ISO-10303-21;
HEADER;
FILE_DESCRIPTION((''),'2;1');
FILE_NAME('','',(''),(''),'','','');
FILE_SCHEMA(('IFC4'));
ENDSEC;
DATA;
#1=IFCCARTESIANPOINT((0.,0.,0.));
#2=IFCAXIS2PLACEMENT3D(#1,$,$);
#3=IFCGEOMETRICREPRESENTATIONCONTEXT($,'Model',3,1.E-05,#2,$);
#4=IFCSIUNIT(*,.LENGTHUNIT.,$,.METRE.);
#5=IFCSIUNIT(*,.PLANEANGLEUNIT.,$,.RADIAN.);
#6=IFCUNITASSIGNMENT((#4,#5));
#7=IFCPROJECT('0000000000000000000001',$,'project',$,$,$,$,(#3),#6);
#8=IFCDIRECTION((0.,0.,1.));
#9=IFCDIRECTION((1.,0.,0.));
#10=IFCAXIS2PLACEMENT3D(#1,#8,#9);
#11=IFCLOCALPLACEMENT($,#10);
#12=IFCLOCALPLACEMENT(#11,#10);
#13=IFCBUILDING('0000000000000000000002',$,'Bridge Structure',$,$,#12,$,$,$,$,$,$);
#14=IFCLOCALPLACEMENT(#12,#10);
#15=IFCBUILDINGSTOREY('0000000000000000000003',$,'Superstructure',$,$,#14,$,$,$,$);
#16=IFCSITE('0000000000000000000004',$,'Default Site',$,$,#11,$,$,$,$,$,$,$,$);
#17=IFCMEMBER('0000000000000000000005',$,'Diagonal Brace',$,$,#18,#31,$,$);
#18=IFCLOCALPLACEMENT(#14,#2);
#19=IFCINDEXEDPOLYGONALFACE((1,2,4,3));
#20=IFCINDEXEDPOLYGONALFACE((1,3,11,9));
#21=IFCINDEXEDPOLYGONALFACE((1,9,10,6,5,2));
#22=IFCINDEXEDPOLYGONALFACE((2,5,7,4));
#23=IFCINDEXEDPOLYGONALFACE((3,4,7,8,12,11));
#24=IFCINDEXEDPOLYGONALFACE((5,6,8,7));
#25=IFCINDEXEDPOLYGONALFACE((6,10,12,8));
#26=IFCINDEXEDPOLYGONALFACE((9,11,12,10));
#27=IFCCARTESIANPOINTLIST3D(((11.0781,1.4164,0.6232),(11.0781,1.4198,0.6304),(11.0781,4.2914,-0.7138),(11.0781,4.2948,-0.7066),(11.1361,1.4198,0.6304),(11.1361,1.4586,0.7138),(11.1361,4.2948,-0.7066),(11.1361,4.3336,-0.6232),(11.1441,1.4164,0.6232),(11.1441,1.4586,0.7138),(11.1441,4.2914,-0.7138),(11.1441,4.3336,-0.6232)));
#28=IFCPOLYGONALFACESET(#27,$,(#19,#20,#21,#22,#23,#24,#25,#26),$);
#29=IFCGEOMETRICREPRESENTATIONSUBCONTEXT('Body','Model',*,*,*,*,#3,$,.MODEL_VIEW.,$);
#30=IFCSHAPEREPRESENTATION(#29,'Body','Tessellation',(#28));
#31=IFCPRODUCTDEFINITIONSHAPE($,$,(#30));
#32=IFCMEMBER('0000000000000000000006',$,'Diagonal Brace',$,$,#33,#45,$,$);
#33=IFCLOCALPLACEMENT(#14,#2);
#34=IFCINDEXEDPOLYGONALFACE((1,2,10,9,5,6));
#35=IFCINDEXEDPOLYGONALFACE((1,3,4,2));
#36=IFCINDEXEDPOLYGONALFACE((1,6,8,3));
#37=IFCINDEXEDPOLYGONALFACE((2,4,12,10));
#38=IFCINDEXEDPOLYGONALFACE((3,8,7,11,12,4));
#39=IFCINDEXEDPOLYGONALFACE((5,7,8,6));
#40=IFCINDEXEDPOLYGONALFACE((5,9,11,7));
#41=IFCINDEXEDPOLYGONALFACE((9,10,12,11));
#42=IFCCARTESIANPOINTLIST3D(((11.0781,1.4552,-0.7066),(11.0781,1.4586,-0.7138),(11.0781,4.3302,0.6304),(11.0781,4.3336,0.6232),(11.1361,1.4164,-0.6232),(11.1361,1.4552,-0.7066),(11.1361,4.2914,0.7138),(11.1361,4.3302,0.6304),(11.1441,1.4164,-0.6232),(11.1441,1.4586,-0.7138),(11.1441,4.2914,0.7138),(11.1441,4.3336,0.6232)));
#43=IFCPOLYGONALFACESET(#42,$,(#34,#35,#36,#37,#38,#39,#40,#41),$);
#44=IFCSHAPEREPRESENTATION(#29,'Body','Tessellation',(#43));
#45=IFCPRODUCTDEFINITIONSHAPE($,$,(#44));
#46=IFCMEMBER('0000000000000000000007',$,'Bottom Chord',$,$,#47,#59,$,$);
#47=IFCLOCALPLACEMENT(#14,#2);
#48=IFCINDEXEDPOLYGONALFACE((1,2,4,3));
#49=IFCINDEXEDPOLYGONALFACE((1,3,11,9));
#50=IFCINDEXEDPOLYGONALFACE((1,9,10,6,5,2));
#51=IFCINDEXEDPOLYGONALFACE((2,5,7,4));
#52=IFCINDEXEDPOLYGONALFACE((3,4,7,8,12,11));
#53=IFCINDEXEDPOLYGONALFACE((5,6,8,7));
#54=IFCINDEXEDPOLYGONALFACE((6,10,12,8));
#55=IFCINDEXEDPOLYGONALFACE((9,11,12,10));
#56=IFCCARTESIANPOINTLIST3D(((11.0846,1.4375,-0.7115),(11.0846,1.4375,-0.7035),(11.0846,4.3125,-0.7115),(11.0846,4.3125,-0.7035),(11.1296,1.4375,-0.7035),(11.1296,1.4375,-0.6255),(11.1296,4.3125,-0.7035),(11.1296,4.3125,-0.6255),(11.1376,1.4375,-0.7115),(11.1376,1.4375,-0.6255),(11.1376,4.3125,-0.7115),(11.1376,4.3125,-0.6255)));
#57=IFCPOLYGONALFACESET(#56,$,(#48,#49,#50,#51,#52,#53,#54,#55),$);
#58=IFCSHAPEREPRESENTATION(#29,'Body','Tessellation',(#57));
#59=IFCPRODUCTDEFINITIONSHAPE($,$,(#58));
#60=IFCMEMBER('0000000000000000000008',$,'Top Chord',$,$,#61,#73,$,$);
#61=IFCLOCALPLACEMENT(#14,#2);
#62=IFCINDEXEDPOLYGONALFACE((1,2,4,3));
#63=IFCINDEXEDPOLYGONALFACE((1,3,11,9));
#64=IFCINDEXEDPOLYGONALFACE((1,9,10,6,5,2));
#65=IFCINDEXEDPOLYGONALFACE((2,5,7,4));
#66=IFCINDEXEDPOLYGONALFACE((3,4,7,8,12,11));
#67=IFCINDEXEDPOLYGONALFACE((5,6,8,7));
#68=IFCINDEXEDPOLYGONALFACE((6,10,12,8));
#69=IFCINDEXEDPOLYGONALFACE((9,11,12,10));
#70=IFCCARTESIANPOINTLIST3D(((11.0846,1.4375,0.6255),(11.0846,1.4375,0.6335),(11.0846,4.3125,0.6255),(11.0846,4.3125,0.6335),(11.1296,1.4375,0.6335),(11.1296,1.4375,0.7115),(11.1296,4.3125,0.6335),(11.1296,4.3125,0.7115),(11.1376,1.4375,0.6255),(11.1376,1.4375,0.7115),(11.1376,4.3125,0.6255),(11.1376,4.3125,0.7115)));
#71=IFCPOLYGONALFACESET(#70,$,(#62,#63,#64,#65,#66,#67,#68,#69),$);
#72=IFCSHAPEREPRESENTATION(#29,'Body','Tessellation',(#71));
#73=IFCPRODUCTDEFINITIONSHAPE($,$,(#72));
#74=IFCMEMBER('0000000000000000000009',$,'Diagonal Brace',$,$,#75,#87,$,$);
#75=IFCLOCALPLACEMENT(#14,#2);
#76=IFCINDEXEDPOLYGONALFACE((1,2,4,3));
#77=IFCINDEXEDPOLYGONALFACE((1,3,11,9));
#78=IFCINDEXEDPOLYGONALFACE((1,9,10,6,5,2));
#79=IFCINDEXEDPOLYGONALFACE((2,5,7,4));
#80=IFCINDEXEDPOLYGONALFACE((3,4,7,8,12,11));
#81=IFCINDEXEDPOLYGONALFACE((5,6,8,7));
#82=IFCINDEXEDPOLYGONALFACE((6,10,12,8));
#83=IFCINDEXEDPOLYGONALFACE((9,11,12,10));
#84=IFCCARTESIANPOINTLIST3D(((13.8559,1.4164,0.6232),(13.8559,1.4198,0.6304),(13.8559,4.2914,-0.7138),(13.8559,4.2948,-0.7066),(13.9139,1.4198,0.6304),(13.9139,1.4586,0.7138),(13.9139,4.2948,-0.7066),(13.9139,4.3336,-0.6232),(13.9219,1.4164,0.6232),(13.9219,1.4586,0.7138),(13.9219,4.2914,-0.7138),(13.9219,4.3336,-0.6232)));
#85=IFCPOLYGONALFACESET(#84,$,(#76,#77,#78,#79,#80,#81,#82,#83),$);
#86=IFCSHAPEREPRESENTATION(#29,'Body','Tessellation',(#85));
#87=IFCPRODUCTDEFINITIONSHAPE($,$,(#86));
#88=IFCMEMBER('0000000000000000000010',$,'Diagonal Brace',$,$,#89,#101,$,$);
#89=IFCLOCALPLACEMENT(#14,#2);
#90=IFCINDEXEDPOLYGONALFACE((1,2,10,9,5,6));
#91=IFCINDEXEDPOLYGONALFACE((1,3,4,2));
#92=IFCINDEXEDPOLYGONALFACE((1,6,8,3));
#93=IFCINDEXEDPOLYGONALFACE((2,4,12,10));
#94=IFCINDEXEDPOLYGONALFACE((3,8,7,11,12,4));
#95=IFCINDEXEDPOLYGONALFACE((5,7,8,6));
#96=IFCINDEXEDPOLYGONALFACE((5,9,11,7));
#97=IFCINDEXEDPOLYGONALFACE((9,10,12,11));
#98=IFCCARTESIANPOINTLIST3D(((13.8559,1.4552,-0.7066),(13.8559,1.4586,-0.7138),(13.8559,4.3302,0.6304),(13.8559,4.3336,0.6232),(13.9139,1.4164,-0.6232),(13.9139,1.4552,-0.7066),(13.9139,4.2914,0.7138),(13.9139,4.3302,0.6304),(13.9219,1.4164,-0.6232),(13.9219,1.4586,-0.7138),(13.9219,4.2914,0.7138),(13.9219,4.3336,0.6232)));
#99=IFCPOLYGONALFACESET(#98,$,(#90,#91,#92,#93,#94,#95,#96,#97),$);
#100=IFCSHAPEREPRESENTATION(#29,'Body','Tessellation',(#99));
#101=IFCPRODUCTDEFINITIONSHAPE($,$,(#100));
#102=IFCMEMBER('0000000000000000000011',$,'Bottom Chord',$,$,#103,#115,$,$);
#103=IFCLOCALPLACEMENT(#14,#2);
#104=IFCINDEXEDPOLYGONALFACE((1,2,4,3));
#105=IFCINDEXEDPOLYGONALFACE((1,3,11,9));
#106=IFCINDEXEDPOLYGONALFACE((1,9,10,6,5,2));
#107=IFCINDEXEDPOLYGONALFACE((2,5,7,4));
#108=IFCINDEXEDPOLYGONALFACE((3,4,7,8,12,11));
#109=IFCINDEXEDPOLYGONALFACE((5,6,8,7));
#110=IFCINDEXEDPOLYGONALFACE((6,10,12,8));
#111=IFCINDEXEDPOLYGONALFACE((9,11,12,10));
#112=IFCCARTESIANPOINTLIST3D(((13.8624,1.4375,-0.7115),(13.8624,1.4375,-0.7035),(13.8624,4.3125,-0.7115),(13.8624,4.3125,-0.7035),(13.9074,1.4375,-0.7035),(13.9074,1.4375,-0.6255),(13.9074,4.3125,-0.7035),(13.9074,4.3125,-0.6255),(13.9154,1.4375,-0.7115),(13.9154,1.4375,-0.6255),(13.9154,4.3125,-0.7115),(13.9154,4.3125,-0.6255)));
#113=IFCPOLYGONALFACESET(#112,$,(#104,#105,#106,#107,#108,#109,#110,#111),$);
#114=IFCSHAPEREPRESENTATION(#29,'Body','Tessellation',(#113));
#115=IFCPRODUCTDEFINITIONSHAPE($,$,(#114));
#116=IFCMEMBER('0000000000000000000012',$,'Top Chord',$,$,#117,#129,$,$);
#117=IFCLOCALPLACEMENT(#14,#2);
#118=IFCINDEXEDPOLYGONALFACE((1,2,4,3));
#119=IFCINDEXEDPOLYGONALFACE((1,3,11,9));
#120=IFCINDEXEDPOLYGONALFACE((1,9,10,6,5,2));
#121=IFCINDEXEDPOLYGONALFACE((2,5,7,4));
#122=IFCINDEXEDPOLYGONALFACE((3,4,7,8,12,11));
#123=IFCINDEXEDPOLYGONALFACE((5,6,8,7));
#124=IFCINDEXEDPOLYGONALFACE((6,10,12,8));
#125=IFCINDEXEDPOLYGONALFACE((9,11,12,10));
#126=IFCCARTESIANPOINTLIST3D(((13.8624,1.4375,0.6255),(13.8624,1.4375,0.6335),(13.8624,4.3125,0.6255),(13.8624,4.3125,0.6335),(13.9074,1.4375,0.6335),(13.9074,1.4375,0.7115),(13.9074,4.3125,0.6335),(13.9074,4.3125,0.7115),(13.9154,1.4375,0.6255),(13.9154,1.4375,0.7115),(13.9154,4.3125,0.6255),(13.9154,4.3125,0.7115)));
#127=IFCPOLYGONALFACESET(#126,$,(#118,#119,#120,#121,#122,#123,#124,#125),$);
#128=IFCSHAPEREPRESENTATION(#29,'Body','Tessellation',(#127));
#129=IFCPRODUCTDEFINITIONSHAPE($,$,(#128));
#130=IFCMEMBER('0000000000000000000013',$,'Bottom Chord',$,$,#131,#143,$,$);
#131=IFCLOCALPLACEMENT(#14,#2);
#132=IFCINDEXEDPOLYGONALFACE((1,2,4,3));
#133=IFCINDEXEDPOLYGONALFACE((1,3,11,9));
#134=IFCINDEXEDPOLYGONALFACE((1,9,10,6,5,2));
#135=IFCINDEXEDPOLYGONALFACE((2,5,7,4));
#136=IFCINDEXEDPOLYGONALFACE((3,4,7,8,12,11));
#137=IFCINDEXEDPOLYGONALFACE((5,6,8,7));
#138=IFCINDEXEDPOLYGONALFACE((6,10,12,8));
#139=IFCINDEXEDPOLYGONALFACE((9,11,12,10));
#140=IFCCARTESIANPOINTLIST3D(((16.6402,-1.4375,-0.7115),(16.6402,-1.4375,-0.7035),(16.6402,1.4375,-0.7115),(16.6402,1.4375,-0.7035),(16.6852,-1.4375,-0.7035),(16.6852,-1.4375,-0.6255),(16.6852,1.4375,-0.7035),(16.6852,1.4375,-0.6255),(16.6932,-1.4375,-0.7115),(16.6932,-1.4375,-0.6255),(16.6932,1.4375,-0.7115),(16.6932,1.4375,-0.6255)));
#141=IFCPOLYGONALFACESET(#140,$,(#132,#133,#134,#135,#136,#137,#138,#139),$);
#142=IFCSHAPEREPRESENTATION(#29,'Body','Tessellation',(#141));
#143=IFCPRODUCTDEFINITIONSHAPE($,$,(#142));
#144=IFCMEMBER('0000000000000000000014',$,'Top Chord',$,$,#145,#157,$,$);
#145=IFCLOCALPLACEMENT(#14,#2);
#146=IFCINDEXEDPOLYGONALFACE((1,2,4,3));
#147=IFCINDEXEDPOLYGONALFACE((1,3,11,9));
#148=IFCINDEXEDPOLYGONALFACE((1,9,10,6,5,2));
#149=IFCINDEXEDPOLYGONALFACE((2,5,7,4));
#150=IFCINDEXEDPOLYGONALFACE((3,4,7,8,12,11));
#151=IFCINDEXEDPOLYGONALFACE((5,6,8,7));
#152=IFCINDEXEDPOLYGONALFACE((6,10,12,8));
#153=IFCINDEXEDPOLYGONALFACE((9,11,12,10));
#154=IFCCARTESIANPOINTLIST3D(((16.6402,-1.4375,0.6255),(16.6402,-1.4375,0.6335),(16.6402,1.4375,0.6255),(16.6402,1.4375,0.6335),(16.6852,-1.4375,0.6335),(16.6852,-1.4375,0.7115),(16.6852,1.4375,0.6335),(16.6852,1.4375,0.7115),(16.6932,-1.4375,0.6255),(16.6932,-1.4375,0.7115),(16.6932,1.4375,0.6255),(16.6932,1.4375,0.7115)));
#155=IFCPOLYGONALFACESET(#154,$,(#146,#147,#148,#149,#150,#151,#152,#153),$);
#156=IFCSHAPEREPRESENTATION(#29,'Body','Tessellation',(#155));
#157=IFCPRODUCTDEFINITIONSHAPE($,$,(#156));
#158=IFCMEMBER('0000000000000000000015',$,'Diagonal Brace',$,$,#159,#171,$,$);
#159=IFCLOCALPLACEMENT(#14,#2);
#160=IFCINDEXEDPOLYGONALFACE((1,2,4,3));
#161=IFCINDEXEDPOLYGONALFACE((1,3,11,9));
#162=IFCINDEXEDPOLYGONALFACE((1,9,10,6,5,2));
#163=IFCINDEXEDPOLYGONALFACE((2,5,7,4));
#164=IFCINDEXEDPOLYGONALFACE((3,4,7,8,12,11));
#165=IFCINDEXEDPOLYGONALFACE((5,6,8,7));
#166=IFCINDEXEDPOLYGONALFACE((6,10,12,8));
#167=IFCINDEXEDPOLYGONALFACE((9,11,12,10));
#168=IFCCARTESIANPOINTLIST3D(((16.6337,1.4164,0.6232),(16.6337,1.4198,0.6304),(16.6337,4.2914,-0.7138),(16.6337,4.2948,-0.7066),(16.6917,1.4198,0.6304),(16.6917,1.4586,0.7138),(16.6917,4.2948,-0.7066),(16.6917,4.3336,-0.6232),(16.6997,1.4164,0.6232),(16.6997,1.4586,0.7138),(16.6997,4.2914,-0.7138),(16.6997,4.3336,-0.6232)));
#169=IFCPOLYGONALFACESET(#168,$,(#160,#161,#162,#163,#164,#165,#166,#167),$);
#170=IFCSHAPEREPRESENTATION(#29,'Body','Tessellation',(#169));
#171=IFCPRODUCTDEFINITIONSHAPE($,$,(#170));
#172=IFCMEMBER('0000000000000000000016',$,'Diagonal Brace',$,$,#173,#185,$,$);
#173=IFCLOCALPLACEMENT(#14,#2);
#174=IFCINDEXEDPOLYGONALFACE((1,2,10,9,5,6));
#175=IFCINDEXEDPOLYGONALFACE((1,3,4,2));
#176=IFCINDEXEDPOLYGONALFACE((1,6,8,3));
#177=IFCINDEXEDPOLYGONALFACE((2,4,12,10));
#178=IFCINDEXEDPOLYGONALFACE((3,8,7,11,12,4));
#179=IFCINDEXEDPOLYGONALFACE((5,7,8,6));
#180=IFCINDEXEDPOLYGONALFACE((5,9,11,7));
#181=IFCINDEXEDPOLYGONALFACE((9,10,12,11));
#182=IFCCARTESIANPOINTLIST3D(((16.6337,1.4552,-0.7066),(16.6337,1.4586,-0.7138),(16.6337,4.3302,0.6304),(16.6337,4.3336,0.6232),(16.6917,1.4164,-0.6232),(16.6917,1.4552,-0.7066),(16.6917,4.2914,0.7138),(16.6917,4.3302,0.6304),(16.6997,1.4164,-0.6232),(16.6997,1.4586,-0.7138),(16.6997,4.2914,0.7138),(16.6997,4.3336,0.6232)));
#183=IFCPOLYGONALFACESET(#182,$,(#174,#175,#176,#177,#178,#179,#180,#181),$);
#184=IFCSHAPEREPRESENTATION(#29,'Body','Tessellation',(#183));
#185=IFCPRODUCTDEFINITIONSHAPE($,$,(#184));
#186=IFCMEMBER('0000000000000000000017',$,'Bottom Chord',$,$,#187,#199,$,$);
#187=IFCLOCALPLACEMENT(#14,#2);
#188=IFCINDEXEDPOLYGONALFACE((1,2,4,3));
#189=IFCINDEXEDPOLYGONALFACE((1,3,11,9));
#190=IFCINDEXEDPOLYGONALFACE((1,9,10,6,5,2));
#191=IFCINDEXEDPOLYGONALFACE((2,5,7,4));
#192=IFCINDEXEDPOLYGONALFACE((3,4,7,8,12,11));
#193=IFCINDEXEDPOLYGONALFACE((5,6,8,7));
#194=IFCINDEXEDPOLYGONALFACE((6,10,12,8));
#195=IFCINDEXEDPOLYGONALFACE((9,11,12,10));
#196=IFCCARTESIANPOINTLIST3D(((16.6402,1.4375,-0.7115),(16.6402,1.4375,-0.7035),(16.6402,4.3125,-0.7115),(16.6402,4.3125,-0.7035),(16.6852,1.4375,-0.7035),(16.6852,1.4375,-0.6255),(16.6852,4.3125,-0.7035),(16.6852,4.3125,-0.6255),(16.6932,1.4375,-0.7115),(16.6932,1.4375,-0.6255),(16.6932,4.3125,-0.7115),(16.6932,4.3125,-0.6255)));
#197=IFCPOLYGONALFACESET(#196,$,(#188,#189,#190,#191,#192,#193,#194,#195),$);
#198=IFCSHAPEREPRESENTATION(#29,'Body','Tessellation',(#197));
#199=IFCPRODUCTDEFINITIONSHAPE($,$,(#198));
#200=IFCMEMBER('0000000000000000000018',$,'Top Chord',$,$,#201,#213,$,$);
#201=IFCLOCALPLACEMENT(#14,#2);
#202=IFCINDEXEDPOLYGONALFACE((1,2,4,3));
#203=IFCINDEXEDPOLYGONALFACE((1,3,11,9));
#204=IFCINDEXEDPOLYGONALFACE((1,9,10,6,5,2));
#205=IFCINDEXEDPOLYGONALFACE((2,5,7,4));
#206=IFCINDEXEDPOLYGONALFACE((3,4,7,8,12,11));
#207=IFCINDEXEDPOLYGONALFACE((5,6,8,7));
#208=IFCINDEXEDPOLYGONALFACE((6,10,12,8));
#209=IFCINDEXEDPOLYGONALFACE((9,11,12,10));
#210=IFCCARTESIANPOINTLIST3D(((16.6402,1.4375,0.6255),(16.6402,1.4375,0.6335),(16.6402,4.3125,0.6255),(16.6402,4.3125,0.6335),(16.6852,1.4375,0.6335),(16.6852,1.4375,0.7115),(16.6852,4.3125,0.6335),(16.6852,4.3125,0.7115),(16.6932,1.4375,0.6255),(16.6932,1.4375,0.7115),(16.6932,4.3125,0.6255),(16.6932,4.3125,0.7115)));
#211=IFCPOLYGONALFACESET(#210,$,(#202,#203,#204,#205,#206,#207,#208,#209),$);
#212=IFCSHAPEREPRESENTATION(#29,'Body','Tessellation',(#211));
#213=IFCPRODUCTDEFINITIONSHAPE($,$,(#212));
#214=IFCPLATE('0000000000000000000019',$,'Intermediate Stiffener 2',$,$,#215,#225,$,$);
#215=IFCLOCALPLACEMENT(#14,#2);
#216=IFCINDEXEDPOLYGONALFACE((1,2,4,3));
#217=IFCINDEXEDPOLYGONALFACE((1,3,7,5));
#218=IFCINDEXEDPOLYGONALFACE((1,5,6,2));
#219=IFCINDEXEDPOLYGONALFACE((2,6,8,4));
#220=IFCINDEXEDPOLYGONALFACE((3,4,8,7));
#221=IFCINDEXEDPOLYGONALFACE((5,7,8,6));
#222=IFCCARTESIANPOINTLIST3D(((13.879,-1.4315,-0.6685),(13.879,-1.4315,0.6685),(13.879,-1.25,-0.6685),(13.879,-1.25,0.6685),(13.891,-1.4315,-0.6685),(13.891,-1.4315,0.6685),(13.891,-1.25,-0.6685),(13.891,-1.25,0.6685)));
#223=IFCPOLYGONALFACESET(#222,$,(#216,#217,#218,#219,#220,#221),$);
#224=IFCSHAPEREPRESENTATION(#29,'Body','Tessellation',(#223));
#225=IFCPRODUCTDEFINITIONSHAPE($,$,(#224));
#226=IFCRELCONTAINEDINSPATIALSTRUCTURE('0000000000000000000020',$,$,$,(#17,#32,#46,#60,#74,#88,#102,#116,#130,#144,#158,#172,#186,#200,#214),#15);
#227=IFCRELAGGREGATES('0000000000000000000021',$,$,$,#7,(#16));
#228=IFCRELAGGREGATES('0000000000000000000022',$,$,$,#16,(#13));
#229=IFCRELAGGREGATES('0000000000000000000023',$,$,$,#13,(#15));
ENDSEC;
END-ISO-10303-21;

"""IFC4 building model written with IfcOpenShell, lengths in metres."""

from ifc_helpers import new_model, si_unit, frame, origin, origin_with_axes, origin_2d_with_axis, place, context, subcontext, project, spatial, rectangle, l_section, extrude, element, save


model = new_model("IFC4")

# Units and contexts
model_context = context("Model", 3, precision=1e-05, world=origin())
body_context = subcontext(model_context, "Body", "Model", "MODEL_VIEW")
ifc_project = project(units=[si_unit("LENGTHUNIT", "METRE"), si_unit("PLANEANGLEUNIT", "RADIAN")], contexts=[model_context])

# Site, building, storey
site_placement = place(None, origin_with_axes())
site = spatial("IfcSite", under=ifc_project, at=site_placement, Name="Default Site")
building_placement = place(site_placement, origin_with_axes())
building = spatial("IfcBuilding", under=site, at=building_placement, Name="Bridge Structure")
storey_placement = place(building_placement, origin_with_axes())
storey = spatial("IfcBuildingStorey", under=building, at=storey_placement, Name="Superstructure")

# Members
for number, where, z_axis, x_axis, name in (
    (1, (11.1111, 1.4375, 0.6685), (0.0, 0.906746, -0.421676), (-1.0, 0.0, 0.0), "Diagonal Brace"),
    (2, (11.1111, 1.4375, -0.6685), (0.0, 0.906746, 0.421676), (-1.0, 0.0, 0.0), "Diagonal Brace"),
):
    element("IfcMember", number, at=place(storey_placement, frame(where, z_axis=z_axis, x_axis=x_axis)), inside=storey, Name=name, context=body_context, shape_type="SweptSolid", body=[
        extrude(l_section(Depth=0.1, Width=0.066, Thickness=0.008, at=origin_2d_with_axis()), origin_with_axes(), (0.0, 0.0, 1.0), 3.1707),
    ])
for number, where, z_axis, x_axis, name in (
    (3, (11.1111, 1.4375, -0.6685), (0.0, 1.0, 0.0), (-1.0, 0.0, 0.0), "Bottom Chord"),
    (4, (11.1111, 1.4375, 0.6685), (0.0, 1.0, 0.0), (-1.0, 0.0, 0.0), "Top Chord"),
):
    element("IfcMember", number, at=place(storey_placement, frame(where, z_axis=z_axis, x_axis=x_axis)), inside=storey, Name=name, context=body_context, shape_type="SweptSolid", body=[
        extrude(l_section(Depth=0.086, Width=0.053, Thickness=0.008, at=origin_2d_with_axis()), origin_with_axes(), (0.0, 0.0, 1.0), 2.875),
    ])
for number, where, z_axis, x_axis, name in (
    (5, (13.8889, 1.4375, 0.6685), (0.0, 0.906746, -0.421676), (-1.0, 0.0, 0.0), "Diagonal Brace"),
    (6, (13.8889, 1.4375, -0.6685), (0.0, 0.906746, 0.421676), (-1.0, 0.0, 0.0), "Diagonal Brace"),
):
    element("IfcMember", number, at=place(storey_placement, frame(where, z_axis=z_axis, x_axis=x_axis)), inside=storey, Name=name, context=body_context, shape_type="SweptSolid", body=[
        extrude(l_section(Depth=0.1, Width=0.066, Thickness=0.008, at=origin_2d_with_axis()), origin_with_axes(), (0.0, 0.0, 1.0), 3.1707),
    ])
for number, where, z_axis, x_axis, name in (
    (7, (13.8889, 1.4375, -0.6685), (0.0, 1.0, 0.0), (-1.0, 0.0, 0.0), "Bottom Chord"),
    (8, (13.8889, 1.4375, 0.6685), (0.0, 1.0, 0.0), (-1.0, 0.0, 0.0), "Top Chord"),
    (9, (16.6667, -1.4375, -0.6685), (0.0, 1.0, 0.0), (-1.0, 0.0, 0.0), "Bottom Chord"),
    (10, (16.6667, -1.4375, 0.6685), (0.0, 1.0, 0.0), (-1.0, 0.0, 0.0), "Top Chord"),
):
    element("IfcMember", number, at=place(storey_placement, frame(where, z_axis=z_axis, x_axis=x_axis)), inside=storey, Name=name, context=body_context, shape_type="SweptSolid", body=[
        extrude(l_section(Depth=0.086, Width=0.053, Thickness=0.008, at=origin_2d_with_axis()), origin_with_axes(), (0.0, 0.0, 1.0), 2.875),
    ])
for number, where, z_axis, x_axis, name in (
    (11, (16.6667, 1.4375, 0.6685), (0.0, 0.906746, -0.421676), (-1.0, 0.0, 0.0), "Diagonal Brace"),
    (12, (16.6667, 1.4375, -0.6685), (0.0, 0.906746, 0.421676), (-1.0, 0.0, 0.0), "Diagonal Brace"),
):
    element("IfcMember", number, at=place(storey_placement, frame(where, z_axis=z_axis, x_axis=x_axis)), inside=storey, Name=name, context=body_context, shape_type="SweptSolid", body=[
        extrude(l_section(Depth=0.1, Width=0.066, Thickness=0.008, at=origin_2d_with_axis()), origin_with_axes(), (0.0, 0.0, 1.0), 3.1707),
    ])
for number, where, z_axis, x_axis, name in (
    (13, (16.6667, 1.4375, -0.6685), (0.0, 1.0, 0.0), (-1.0, 0.0, 0.0), "Bottom Chord"),
    (14, (16.6667, 1.4375, 0.6685), (0.0, 1.0, 0.0), (-1.0, 0.0, 0.0), "Top Chord"),
):
    element("IfcMember", number, at=place(storey_placement, frame(where, z_axis=z_axis, x_axis=x_axis)), inside=storey, Name=name, context=body_context, shape_type="SweptSolid", body=[
        extrude(l_section(Depth=0.086, Width=0.053, Thickness=0.008, at=origin_2d_with_axis()), origin_with_axes(), (0.0, 0.0, 1.0), 2.875),
    ])

# Plate
for number, where, z_axis, x_axis, name in (
    (15, (13.885, -1.3408, -0.6685), (0.0, 0.0, 1.0), (1.0, 0.0, 0.0), "Intermediate Stiffener 2"),
):
    element("IfcPlate", number, at=place(storey_placement, frame(where, z_axis=z_axis, x_axis=x_axis)), inside=storey, Name=name, context=body_context, shape_type="SweptSolid", body=[
        extrude(rectangle(XDim=0.012, YDim=0.1815, at=origin_2d_with_axis()), origin_with_axes(), (0.0, 0.0, 1.0), 1.337),
    ])

save(model, "model.ifc")
